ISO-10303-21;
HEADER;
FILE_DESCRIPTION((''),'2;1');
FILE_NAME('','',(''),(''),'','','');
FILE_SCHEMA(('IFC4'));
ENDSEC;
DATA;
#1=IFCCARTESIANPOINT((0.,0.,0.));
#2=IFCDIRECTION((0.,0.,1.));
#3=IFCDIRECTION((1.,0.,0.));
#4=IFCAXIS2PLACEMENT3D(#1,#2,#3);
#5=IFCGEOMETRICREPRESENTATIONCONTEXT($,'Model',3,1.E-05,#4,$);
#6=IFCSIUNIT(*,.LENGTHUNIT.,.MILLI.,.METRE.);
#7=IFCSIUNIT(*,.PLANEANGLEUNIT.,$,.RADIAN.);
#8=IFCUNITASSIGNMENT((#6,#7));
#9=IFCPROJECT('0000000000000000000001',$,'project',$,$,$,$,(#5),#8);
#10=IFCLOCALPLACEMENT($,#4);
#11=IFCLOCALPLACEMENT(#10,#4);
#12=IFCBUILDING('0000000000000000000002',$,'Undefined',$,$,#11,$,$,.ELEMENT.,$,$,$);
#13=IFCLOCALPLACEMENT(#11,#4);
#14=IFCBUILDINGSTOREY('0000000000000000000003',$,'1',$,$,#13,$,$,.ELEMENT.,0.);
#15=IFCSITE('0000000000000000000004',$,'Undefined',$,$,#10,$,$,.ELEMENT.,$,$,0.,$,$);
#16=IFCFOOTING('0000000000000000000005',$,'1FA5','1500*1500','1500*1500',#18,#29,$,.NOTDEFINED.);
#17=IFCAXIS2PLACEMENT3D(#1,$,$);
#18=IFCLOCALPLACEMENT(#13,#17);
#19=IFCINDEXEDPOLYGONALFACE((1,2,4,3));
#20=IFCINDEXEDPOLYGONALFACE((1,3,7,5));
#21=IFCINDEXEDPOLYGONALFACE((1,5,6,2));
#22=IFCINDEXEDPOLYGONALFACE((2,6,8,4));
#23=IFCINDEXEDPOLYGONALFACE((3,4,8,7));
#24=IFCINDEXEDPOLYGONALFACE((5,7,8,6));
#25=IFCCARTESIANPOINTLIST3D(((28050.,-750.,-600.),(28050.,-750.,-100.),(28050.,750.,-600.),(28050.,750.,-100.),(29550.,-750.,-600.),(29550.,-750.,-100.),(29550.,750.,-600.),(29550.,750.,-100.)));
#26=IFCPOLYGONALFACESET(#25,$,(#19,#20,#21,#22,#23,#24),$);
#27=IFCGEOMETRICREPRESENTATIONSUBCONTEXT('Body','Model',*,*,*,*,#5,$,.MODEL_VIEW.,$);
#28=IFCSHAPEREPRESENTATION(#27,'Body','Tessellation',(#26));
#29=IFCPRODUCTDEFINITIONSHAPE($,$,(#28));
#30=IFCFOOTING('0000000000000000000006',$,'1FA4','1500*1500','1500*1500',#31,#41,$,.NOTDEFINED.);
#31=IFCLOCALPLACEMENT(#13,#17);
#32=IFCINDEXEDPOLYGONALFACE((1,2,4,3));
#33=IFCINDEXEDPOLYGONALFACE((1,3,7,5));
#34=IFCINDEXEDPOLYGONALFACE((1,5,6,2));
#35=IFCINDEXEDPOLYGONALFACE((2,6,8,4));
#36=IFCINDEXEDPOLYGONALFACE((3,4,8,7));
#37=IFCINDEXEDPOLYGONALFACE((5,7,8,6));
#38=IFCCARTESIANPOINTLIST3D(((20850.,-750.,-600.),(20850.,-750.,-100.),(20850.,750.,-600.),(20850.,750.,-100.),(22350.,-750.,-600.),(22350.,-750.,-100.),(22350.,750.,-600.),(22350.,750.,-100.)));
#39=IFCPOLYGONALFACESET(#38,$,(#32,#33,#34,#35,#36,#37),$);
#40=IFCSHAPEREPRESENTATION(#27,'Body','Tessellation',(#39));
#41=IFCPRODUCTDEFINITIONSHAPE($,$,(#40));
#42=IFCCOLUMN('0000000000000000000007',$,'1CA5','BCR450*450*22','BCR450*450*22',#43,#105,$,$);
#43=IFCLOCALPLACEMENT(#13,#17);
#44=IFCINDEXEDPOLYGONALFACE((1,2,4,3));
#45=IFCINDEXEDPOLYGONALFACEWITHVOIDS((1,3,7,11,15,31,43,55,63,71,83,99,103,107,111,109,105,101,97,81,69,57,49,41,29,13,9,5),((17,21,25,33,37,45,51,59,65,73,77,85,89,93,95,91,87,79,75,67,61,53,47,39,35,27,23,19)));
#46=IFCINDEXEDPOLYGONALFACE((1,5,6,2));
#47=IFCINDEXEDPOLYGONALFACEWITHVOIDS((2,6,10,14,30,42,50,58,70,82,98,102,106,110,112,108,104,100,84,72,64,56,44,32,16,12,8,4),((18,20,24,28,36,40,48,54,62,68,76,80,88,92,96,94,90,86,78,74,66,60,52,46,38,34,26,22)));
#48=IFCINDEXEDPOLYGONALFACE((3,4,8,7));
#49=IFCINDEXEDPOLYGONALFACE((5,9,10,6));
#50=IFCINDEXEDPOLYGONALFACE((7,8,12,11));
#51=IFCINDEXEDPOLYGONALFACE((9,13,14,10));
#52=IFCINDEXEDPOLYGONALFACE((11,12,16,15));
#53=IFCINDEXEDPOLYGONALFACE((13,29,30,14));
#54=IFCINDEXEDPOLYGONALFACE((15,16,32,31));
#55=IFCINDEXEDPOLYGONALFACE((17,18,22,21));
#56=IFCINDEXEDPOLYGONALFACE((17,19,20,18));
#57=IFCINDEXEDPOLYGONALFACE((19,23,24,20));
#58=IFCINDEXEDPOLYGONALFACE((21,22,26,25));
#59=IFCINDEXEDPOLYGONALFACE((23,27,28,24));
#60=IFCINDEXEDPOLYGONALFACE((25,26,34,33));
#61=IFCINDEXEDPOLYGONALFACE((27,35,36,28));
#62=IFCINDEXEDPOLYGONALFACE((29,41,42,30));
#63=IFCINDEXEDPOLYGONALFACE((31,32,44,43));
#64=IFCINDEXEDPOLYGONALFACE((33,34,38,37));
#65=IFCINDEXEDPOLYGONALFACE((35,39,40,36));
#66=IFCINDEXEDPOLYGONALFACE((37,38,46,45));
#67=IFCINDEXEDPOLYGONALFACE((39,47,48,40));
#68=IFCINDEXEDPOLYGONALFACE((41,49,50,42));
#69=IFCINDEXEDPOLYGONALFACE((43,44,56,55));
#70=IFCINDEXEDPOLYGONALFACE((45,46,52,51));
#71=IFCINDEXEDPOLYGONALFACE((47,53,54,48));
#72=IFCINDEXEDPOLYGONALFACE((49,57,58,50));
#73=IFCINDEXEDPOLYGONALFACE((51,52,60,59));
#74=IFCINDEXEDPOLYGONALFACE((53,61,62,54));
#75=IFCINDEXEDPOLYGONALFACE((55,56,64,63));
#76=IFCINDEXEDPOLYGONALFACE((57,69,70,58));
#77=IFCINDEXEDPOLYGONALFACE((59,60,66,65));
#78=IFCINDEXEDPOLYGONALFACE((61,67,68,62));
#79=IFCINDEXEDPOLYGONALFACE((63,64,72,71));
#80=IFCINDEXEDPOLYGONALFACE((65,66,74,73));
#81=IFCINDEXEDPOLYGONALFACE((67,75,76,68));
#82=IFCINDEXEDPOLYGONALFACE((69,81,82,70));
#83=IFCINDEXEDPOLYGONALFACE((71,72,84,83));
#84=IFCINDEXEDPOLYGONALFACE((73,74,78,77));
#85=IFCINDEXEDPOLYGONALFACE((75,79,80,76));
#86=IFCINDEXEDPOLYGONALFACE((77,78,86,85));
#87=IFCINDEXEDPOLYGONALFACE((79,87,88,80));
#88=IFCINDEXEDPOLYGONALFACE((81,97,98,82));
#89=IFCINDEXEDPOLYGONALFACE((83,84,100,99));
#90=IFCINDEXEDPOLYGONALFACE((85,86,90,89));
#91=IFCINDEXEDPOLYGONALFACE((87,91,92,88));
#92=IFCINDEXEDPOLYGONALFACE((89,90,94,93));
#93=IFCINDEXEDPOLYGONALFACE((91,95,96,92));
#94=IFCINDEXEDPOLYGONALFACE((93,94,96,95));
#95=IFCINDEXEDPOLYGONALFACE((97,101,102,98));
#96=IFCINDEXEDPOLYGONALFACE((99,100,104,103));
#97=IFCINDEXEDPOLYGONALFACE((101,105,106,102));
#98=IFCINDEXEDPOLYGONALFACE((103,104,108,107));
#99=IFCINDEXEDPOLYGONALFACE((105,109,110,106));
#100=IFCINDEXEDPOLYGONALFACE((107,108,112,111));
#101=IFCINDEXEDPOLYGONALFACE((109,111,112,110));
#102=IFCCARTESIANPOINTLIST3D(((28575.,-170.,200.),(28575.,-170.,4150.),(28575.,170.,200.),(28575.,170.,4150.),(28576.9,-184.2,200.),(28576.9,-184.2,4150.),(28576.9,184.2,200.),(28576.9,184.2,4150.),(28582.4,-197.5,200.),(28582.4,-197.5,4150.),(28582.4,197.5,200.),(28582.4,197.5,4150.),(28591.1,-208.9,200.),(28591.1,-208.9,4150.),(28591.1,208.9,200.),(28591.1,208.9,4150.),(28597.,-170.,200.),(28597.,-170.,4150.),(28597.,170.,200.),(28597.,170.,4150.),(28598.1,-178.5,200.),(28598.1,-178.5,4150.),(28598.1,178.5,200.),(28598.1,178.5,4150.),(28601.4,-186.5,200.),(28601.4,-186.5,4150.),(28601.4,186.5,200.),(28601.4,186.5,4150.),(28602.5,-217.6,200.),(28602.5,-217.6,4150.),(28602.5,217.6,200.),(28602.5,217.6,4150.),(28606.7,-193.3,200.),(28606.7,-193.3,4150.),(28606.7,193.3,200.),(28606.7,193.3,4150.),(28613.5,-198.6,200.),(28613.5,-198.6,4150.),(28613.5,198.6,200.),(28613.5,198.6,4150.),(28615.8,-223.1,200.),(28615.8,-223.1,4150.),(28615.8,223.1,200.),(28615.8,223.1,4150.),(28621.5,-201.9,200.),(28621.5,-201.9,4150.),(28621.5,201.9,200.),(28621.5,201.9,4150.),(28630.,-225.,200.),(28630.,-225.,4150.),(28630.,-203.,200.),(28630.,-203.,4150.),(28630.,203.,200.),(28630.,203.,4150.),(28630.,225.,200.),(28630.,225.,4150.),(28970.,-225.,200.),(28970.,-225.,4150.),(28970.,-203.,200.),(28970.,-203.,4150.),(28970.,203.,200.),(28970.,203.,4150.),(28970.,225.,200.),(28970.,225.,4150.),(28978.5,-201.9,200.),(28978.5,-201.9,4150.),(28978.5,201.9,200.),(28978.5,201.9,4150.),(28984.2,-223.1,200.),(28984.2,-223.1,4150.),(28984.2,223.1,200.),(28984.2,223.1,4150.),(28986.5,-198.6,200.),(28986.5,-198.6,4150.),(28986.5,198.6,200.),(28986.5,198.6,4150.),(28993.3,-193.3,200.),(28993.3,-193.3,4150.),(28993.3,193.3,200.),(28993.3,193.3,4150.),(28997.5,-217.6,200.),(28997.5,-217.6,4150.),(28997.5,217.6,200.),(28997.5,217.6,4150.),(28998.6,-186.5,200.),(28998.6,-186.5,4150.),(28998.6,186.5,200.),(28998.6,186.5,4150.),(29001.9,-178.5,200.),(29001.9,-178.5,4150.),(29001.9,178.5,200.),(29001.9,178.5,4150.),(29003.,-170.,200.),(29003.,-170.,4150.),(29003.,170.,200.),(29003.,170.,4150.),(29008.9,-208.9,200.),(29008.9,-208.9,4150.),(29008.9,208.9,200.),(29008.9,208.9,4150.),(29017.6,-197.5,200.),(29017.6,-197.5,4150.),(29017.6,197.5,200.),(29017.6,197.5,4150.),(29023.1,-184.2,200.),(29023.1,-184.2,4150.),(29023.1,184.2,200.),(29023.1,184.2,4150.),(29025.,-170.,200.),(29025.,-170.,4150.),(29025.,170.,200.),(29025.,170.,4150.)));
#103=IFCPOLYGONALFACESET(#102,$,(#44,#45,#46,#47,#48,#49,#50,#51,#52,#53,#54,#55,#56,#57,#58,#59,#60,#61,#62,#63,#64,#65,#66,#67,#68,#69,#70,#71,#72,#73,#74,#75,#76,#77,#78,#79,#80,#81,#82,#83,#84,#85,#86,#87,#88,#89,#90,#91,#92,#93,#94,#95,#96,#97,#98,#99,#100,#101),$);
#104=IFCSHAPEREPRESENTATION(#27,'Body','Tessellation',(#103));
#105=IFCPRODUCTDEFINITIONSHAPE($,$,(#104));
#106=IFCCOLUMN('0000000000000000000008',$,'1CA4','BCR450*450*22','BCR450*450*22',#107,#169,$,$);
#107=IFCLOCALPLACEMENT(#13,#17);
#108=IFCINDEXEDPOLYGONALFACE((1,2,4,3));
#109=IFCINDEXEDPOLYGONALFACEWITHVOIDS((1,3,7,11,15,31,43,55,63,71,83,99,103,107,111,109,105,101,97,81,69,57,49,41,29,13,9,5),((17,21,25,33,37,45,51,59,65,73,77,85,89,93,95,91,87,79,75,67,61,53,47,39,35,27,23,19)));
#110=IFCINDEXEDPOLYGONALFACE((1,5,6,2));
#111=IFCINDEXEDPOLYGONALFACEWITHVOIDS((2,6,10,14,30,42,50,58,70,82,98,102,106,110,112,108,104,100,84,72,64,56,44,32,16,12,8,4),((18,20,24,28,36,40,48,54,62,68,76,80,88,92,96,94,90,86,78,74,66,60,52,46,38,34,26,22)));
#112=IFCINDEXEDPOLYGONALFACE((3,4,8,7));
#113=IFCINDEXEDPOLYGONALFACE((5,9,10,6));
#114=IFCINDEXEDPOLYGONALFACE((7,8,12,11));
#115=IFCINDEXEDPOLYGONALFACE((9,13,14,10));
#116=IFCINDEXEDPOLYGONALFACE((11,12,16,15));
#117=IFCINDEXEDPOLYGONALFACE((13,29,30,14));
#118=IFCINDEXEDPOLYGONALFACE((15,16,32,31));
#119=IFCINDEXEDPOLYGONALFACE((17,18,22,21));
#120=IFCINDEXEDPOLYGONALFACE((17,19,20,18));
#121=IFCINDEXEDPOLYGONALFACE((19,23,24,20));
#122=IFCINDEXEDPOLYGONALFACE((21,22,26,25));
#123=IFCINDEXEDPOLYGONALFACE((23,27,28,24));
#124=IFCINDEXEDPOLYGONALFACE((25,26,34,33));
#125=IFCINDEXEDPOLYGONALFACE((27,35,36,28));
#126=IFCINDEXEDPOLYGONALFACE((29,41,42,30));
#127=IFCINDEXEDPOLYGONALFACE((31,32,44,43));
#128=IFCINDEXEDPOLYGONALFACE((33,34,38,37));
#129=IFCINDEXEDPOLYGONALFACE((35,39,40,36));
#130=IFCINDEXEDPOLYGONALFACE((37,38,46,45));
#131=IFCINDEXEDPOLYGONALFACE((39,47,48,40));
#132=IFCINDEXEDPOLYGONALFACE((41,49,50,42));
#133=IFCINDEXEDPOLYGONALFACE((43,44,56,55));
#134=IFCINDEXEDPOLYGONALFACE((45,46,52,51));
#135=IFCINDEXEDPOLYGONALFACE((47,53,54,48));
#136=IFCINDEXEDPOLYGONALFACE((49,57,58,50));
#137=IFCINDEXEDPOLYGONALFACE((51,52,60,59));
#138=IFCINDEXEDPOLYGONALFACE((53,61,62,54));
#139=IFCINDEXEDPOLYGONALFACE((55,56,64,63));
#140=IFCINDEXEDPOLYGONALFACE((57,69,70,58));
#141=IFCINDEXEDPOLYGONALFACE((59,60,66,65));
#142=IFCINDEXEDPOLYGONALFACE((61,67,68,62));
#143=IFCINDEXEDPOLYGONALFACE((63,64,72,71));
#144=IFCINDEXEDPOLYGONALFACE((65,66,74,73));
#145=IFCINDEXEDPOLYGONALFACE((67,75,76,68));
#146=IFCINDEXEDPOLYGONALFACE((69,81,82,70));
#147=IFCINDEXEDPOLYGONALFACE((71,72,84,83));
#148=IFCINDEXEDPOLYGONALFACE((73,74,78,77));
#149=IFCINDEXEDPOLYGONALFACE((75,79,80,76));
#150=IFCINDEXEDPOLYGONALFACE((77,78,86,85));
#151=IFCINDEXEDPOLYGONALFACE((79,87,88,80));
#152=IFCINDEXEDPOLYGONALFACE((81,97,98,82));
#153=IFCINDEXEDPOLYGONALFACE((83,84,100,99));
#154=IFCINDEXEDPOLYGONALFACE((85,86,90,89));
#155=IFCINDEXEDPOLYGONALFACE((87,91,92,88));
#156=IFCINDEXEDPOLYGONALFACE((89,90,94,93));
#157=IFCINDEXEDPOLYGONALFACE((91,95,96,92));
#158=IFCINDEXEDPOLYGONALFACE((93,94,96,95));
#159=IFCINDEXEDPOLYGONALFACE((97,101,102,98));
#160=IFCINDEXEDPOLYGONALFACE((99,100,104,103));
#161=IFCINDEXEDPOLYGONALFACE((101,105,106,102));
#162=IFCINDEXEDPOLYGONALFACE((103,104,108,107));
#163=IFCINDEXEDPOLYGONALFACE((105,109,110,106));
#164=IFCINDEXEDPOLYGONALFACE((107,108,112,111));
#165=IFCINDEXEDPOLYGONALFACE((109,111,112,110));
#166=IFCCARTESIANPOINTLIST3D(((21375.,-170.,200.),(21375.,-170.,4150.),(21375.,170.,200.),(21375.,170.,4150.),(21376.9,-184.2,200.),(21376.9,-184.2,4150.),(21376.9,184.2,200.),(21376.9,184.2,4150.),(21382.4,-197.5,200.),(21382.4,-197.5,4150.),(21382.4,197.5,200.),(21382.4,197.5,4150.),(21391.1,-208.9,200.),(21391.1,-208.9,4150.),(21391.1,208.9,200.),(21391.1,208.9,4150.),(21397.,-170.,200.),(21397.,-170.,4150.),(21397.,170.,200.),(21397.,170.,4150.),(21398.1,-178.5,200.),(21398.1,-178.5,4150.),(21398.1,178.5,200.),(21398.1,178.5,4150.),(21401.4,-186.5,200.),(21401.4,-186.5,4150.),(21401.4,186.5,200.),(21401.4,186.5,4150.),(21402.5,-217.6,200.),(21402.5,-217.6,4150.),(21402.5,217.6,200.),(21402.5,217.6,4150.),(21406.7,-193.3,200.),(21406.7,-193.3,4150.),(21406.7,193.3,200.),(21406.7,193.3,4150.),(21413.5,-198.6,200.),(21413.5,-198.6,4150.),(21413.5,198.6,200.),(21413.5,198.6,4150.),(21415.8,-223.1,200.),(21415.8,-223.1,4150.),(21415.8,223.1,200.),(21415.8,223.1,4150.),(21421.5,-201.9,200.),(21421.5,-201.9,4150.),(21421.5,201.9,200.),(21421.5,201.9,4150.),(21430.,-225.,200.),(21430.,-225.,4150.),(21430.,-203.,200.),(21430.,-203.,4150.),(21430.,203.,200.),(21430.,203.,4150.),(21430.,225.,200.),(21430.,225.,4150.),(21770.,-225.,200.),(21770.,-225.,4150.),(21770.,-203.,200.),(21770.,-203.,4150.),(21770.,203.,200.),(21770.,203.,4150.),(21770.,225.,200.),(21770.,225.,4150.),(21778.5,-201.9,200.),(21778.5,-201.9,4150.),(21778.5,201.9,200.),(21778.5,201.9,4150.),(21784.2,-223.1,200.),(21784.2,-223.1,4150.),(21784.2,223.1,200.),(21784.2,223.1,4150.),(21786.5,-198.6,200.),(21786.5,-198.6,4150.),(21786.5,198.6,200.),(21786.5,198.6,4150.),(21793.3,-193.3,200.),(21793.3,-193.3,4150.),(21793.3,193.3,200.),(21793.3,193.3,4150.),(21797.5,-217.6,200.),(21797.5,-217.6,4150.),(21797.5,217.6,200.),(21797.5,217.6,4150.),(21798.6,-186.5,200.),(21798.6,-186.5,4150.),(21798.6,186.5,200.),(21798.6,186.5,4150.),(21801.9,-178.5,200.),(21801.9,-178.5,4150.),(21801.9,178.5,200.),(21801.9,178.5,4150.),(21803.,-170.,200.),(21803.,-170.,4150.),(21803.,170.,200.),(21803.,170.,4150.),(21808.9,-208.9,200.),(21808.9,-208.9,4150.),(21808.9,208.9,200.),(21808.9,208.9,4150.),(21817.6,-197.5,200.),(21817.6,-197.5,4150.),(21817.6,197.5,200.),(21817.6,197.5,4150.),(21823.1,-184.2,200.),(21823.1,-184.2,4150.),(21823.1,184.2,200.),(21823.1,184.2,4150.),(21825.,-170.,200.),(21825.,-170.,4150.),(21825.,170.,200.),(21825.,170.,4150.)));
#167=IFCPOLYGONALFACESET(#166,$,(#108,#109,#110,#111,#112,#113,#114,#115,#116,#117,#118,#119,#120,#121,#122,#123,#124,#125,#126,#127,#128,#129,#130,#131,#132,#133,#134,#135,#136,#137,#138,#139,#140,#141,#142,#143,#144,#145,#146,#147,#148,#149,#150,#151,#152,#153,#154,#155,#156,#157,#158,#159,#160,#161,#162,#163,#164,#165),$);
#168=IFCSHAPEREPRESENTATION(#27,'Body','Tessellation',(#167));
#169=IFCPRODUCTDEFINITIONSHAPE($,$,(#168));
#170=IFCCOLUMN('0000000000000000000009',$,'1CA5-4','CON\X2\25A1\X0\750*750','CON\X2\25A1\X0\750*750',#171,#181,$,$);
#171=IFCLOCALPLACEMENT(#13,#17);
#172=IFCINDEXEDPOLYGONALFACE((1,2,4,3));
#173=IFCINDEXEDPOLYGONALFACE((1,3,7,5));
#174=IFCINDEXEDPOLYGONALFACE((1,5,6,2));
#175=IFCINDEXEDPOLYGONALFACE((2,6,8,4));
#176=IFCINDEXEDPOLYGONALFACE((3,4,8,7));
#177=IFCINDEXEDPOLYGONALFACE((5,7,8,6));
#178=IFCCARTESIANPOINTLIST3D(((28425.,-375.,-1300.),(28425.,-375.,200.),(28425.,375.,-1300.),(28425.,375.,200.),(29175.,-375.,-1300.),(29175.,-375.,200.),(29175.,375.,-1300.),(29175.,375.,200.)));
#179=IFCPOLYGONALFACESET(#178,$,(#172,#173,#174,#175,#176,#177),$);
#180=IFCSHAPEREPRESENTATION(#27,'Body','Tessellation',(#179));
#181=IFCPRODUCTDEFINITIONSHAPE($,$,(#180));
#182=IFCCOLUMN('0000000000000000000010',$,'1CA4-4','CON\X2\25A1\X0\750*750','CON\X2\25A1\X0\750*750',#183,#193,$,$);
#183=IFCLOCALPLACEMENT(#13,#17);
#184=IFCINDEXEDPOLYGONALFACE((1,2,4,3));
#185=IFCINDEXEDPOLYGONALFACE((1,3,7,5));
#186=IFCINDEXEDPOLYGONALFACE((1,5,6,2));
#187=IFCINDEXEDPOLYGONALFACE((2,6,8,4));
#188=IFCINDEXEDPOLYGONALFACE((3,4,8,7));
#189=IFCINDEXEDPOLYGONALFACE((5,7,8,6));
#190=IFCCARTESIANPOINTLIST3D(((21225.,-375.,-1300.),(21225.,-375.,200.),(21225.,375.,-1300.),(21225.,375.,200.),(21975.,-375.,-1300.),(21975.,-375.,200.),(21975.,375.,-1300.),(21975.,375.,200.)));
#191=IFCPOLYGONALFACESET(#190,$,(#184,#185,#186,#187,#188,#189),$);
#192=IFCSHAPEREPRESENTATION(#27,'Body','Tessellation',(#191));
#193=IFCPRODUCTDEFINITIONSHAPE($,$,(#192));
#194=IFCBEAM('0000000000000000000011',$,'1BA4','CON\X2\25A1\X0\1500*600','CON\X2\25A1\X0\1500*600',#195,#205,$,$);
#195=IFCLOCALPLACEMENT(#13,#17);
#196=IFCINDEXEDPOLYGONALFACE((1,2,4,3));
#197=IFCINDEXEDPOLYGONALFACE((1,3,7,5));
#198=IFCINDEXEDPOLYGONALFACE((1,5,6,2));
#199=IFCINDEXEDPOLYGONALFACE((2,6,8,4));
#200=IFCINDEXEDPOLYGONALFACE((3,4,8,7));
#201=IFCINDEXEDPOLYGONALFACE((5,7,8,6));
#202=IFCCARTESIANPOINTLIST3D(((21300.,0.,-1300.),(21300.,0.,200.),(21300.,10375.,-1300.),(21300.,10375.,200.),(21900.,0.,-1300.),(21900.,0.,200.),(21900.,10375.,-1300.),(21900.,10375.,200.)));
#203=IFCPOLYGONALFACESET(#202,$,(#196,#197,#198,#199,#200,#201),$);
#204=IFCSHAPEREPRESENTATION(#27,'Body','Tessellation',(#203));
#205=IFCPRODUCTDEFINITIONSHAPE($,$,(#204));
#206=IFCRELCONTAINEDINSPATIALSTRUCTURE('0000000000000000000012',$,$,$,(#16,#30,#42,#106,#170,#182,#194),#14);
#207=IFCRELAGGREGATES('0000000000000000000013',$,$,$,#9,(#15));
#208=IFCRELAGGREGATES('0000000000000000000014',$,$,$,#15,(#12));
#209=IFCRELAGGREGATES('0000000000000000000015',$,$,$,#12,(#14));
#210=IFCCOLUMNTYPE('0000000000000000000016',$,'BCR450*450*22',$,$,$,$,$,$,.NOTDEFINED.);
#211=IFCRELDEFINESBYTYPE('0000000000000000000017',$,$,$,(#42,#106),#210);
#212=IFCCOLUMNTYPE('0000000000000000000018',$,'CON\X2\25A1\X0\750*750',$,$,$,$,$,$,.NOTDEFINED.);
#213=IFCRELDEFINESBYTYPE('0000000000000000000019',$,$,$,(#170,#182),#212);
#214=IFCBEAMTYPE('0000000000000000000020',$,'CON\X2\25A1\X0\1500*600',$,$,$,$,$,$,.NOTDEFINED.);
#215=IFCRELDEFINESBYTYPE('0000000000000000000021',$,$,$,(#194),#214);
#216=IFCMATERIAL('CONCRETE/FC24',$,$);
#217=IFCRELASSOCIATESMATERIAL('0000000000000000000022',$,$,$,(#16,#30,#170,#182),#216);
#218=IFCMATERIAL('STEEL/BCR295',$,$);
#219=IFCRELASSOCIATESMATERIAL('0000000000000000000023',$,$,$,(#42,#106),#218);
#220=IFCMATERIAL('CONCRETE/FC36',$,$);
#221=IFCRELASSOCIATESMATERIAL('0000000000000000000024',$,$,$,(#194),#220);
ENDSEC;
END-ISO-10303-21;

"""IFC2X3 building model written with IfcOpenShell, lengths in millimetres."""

from ifc_helpers import new_model, si_unit, frame, origin_with_axes, origin_2d_with_axis, place, context, subcontext, project, spatial, rectangle, hollow_rectangle, extrude, material, type_object, element, save


model = new_model("IFC2X3")

# Units and contexts
model_context = context("Model", 3, precision=1e-05, world=origin_with_axes())
body_context = subcontext(model_context, "Body", "Model", "MODEL_VIEW")
ifc_project = project(units=[si_unit("LENGTHUNIT", "METRE", prefix="MILLI"), si_unit("PLANEANGLEUNIT", "RADIAN")], contexts=[model_context])

# Site, building, storey
site_placement = place(None, origin_with_axes())
site = spatial("IfcSite", under=ifc_project, at=site_placement, Name="Undefined", CompositionType="ELEMENT", RefElevation=0.0)
building_placement = place(site_placement, origin_with_axes())
building = spatial("IfcBuilding", under=site, at=building_placement, Name="Undefined", CompositionType="ELEMENT")
storey_placement = place(building_placement, origin_with_axes())
storey = spatial("IfcBuildingStorey", under=building, at=storey_placement, Name="1", CompositionType="ELEMENT", Elevation=0.0)

# Footings
ifc_material_1 = material(Name="CONCRETE/FC24")
for number, where, z_axis, x_axis, name in (
    (1, (28800.0, 0.0, -600.0), (0.0, 1.0, 0.0), (0.0, 0.0, 1.0), "1FA5"),
    (2, (21600.0, 0.0, -600.0), (0.0, 1.0, 0.0), (0.0, 0.0, 1.0), "1FA4"),
):
    element("IfcFooting", number, at=place(storey_placement, frame(where, z_axis=z_axis, x_axis=x_axis)), inside=storey, material=ifc_material_1, Name=name, Description="1500*1500", ObjectType="1500*1500", PredefinedType="NOTDEFINED", context=body_context, shape_type="SweptSolid", body=[
        extrude(rectangle(XDim=1500.0, YDim=1500.0, at=origin_2d_with_axis()), frame((500.0, 0.0, 0.0), z_axis=(-1.0, 0.0, 0.0), x_axis=(0.0, -1.0, 0.0)), (0.0, 0.0, 1.0), 500.0),
    ])

# Columns
ifc_material_2 = material(Name="STEEL/BCR295")
column_type_1 = type_object("IfcColumnType", Name="BCR450*450*22", PredefinedType="NOTDEFINED")
for number, where, z_axis, x_axis, name in (
    (3, (28800.0, 0.0, 200.0), (0.0, 0.0, 1.0), (0.0, 1.0, 0.0), "1CA5"),
    (4, (21600.0, 0.0, 200.0), (0.0, 0.0, 1.0), (0.0, 1.0, 0.0), "1CA4"),
):
    element("IfcColumn", number, at=place(storey_placement, frame(where, z_axis=z_axis, x_axis=x_axis)), inside=storey, type_object=column_type_1, material=ifc_material_2, Name=name, Description="BCR450*450*22", ObjectType="BCR450*450*22", context=body_context, shape_type="SweptSolid", body=[
        extrude(hollow_rectangle(XDim=450.0, YDim=450.0, WallThickness=22.0, InnerFilletRadius=33.0, OuterFilletRadius=55.0, at=origin_2d_with_axis()), frame((0.0, 0.0, 3950.0), z_axis=(0.0, 0.0, -1.0), x_axis=(0.0, 1.0, 0.0)), (0.0, 0.0, 1.0), 3950.0),
    ])
column_type_2 = type_object("IfcColumnType", Name="CON□750*750", PredefinedType="NOTDEFINED")
for number, where, z_axis, x_axis, name in (
    (5, (28800.0, 0.0, -1300.0), (0.0, 0.0, 1.0), (0.0, 1.0, 0.0), "1CA5-4"),
    (6, (21600.0, 0.0, -1300.0), (0.0, 0.0, 1.0), (0.0, 1.0, 0.0), "1CA4-4"),
):
    element("IfcColumn", number, at=place(storey_placement, frame(where, z_axis=z_axis, x_axis=x_axis)), inside=storey, type_object=column_type_2, material=ifc_material_1, Name=name, Description="CON□750*750", ObjectType="CON□750*750", context=body_context, shape_type="SweptSolid", body=[
        extrude(rectangle(XDim=750.0, YDim=750.0, at=origin_2d_with_axis()), frame((0.0, 0.0, 1500.0), z_axis=(0.0, 0.0, -1.0), x_axis=(0.0, 1.0, 0.0)), (0.0, 0.0, 1.0), 1500.0),
    ])

# Beam
ifc_material_3 = material(Name="CONCRETE/FC36")
beam_type_1 = type_object("IfcBeamType", Name="CON□1500*600", PredefinedType="NOTDEFINED")
beam_1_placement = place(storey_placement, frame((21600.0, 0.0, -550.0), z_axis=(0.0, 0.0, 1.0), x_axis=(0.0, 1.0, 0.0)))
element("IfcBeam", 7, at=beam_1_placement, inside=storey, type_object=beam_type_1, material=ifc_material_3, Name="1BA4", Description="CON□1500*600", ObjectType="CON□1500*600", context=body_context, shape_type="SweptSolid", body=[
    extrude(rectangle(XDim=600.0, YDim=1500.0, at=origin_2d_with_axis()), frame((10375.0, 0.0, 0.0), z_axis=(-1.0, 0.0, 0.0), x_axis=(0.0, -1.0, 0.0)), (0.0, 0.0, 1.0), 10375.0),
])

save(model, "model.ifc")
